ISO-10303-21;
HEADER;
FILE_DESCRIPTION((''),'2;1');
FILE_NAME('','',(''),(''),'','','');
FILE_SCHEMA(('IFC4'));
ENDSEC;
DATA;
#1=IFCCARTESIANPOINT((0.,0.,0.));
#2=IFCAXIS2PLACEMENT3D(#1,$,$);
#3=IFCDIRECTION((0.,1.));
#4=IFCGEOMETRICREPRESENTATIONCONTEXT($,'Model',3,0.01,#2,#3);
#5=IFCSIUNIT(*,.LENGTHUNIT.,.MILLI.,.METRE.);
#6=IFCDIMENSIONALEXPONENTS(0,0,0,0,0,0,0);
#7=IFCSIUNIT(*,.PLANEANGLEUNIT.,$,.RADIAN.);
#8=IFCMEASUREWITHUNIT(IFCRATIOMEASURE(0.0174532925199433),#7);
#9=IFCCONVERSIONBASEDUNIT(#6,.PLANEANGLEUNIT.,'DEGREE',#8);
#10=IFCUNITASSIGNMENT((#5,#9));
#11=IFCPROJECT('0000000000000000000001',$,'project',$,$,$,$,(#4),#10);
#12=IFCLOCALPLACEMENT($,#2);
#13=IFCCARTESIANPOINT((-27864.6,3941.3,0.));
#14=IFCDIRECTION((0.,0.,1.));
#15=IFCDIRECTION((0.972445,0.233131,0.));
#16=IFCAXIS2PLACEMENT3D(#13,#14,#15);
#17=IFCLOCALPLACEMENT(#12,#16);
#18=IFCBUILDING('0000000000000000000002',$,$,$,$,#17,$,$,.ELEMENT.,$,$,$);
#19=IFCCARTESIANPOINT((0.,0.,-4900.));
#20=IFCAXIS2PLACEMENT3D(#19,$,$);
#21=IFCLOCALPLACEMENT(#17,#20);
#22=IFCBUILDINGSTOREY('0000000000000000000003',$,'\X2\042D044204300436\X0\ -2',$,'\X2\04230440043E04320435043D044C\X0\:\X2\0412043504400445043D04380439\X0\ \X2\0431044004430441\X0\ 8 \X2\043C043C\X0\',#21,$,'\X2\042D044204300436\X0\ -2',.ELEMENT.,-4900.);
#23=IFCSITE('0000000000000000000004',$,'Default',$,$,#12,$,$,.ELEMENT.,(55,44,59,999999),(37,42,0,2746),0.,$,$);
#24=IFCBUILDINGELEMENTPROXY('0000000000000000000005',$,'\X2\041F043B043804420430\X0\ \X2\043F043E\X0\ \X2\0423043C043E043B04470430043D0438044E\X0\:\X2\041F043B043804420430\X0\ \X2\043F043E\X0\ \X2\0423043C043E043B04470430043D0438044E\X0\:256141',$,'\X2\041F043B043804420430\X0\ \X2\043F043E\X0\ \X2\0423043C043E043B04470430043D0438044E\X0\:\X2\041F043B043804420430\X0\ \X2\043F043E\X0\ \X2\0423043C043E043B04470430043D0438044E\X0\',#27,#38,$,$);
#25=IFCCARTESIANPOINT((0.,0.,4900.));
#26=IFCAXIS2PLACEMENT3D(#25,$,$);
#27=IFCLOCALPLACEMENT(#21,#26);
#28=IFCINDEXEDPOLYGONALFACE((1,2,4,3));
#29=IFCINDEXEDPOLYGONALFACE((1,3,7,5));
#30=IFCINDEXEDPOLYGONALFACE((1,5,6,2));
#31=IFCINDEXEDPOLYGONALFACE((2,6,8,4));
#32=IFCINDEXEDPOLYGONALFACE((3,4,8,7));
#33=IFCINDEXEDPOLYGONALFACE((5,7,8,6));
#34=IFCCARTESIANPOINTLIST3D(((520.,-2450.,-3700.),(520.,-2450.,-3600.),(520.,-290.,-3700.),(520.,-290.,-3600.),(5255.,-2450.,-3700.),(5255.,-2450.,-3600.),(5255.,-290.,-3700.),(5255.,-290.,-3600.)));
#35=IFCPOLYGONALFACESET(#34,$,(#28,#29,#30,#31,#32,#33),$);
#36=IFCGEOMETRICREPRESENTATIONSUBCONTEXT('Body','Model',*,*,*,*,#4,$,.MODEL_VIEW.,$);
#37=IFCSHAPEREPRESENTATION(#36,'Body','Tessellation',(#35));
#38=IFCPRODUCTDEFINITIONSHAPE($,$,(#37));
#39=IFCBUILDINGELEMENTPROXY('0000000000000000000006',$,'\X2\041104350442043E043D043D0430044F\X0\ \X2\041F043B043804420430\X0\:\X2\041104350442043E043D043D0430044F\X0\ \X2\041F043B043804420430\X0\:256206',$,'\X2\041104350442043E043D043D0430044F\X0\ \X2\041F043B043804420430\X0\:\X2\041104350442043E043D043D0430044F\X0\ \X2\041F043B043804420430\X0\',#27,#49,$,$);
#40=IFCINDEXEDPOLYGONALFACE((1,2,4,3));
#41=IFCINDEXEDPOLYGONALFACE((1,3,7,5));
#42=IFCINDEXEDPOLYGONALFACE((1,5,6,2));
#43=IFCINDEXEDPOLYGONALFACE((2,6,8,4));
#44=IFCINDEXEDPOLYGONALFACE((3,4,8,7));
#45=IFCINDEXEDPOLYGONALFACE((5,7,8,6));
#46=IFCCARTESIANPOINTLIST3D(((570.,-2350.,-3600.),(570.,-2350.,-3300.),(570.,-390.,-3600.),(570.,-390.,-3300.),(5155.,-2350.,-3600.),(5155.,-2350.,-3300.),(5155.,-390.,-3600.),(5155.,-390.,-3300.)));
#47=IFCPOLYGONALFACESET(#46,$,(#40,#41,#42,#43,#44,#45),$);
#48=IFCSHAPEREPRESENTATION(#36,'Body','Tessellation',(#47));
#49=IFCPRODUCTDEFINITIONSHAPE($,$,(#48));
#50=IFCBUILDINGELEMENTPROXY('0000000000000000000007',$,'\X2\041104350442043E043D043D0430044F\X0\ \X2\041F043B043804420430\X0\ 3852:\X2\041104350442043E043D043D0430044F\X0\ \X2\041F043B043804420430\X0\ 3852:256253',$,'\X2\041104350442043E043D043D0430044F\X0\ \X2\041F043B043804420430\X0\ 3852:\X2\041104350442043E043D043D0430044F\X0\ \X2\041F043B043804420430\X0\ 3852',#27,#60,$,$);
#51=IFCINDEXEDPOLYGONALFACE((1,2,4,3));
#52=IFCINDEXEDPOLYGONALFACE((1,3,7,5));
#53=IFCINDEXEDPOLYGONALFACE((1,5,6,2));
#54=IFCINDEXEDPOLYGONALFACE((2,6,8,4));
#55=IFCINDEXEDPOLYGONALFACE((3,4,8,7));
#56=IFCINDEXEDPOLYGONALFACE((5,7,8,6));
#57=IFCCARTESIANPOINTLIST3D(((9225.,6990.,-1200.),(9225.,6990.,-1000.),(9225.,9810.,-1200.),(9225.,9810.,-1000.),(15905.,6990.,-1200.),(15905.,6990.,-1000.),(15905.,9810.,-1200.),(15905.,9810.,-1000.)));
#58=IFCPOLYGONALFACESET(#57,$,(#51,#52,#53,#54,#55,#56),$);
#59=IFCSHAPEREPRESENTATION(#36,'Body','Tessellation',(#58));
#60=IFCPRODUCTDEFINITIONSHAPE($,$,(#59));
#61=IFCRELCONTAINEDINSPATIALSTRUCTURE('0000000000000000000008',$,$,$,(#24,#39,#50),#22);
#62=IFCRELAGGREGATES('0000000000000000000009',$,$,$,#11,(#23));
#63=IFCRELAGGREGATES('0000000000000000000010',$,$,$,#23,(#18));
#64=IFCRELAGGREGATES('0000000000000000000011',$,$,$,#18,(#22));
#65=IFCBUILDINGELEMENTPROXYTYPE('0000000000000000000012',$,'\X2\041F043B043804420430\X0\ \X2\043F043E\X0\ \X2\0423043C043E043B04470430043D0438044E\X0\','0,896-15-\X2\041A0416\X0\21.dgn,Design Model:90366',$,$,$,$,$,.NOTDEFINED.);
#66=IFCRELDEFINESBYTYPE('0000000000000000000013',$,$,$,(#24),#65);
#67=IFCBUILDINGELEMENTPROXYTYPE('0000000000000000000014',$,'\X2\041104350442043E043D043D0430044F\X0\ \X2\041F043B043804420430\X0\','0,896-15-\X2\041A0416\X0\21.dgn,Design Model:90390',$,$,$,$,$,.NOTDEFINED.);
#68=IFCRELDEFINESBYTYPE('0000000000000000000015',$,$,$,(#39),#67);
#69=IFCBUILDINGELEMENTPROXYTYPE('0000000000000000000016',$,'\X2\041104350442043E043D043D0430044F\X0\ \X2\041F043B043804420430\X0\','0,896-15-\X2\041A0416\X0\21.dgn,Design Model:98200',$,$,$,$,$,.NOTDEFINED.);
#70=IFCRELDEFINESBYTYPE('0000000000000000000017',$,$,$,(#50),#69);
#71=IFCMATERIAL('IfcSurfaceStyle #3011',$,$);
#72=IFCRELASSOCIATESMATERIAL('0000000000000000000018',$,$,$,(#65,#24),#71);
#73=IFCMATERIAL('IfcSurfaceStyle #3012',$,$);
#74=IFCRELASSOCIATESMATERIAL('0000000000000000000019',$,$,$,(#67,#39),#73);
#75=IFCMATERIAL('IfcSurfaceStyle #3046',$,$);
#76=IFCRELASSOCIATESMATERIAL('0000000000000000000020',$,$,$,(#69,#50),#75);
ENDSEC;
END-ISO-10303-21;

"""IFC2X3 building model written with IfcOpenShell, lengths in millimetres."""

from ifc_helpers import new_model, entity, si_unit, converted_unit, direction, frame, origin, origin_2d_with_axis, place, context, subcontext, project, spatial, rectangle, extrude, source, transform, mapped, material, type_object, type_shapes, element, save


model = new_model("IFC2X3")

# Units and contexts
model_context = context("Model", 3, precision=0.01, world=origin(), true_north=direction((0.0, 1.0)))
body_context = subcontext(model_context, "Body", "Model", "MODEL_VIEW")
ifc_project = project(units=[si_unit("LENGTHUNIT", "METRE", prefix="MILLI"), converted_unit("PLANEANGLEUNIT", "DEGREE", entity("IfcRatioMeasure", 0.0174532925199433), si_unit("PLANEANGLEUNIT", "RADIAN"), dimensions=[0, 0, 0, 0, 0, 0, 0])], contexts=[model_context])

# Site, building, storey
site_placement = place(None, origin())
site = spatial("IfcSite", under=ifc_project, at=site_placement, Name="Default", CompositionType="ELEMENT", RefLatitude=(55, 44, 59, 999999), RefLongitude=(37, 42, 0, 2746), RefElevation=0.0)
building_placement = place(site_placement, frame((-27864.6, 3941.3, 0.0), z_axis=(0.0, 0.0, 1.0), x_axis=(0.972445, 0.233131, 0.0)))
building = spatial("IfcBuilding", under=site, at=building_placement, CompositionType="ELEMENT")
storey_placement = place(building_placement, frame((0.0, 0.0, -4900.0)))
storey = spatial("IfcBuildingStorey", under=building, at=storey_placement, Name="Этаж -2", ObjectType="Уровень:Верхний брус 8 мм", LongName="Этаж -2", CompositionType="ELEMENT", Elevation=-4900.0)

# Building element proxies
ifc_material_1 = material(Name="IfcSurfaceStyle #3011")
building_element_proxy_type_1 = type_object("IfcBuildingElementProxyType", Name="Плита по Умолчанию", Description="0,896-15-КЖ21.dgn,Design Model:90366", PredefinedType="NOTDEFINED", material=ifc_material_1)
shared_shape_1 = source(origin(), body_context, "Body", "SweptSolid", [
    extrude(rectangle(XDim=2160.0, YDim=4735.0, at=origin_2d_with_axis()), frame((2887.5, -1370.0, -3700.0), z_axis=(0.0, 0.0, 1.0), x_axis=(0.0, 1.0, 0.0)), (0.0, 0.0, 1.0), 100.0),
])
type_shapes(building_element_proxy_type_1, [shared_shape_1])
placement = place(storey_placement, frame((0.0, 0.0, 4900.0)))
element("IfcBuildingElementProxy", 1, at=placement, inside=storey, type_object=building_element_proxy_type_1, material=ifc_material_1, Name="Плита по Умолчанию:Плита по Умолчанию:256141", ObjectType="Плита по Умолчанию:Плита по Умолчанию", context=body_context, shape_type="MappedRepresentation", body=[
    mapped(shared_shape_1, transform((0.0, 0.0, 0.0), scale=1.0)),
])
ifc_material_2 = material(Name="IfcSurfaceStyle #3012")
building_element_proxy_type_2 = type_object("IfcBuildingElementProxyType", Name="Бетонная Плита", Description="0,896-15-КЖ21.dgn,Design Model:90390", PredefinedType="NOTDEFINED", material=ifc_material_2)
shared_shape_2 = source(origin(), body_context, "Body", "SweptSolid", [
    extrude(rectangle(XDim=4585.0, YDim=1960.0, at=origin_2d_with_axis()), frame((2862.5, -1370.0, -3600.0), z_axis=(0.0, 0.0, 1.0), x_axis=(-1.0, 0.0, 0.0)), (0.0, 0.0, 1.0), 300.0),
])
type_shapes(building_element_proxy_type_2, [shared_shape_2])
element("IfcBuildingElementProxy", 2, at=placement, inside=storey, type_object=building_element_proxy_type_2, material=ifc_material_2, Name="Бетонная Плита:Бетонная Плита:256206", ObjectType="Бетонная Плита:Бетонная Плита", context=body_context, shape_type="MappedRepresentation", body=[
    mapped(shared_shape_2, transform((0.0, 0.0, 0.0), scale=1.0)),
])
ifc_material_3 = material(Name="IfcSurfaceStyle #3046")
building_element_proxy_type_3 = type_object("IfcBuildingElementProxyType", Name="Бетонная Плита", Description="0,896-15-КЖ21.dgn,Design Model:98200", PredefinedType="NOTDEFINED", material=ifc_material_3)
shared_shape_3 = source(origin(), body_context, "Body", "SweptSolid", [
    extrude(rectangle(XDim=2820.0, YDim=6680.0, at=origin_2d_with_axis()), frame((12565.0, 8400.0, -1200.0), z_axis=(0.0, 0.0, 1.0), x_axis=(0.0, 1.0, 0.0)), (0.0, 0.0, 1.0), 200.0),
])
type_shapes(building_element_proxy_type_3, [shared_shape_3])
element("IfcBuildingElementProxy", 3, at=placement, inside=storey, type_object=building_element_proxy_type_3, material=ifc_material_3, Name="Бетонная Плита 3852:Бетонная Плита 3852:256253", ObjectType="Бетонная Плита 3852:Бетонная Плита 3852", context=body_context, shape_type="MappedRepresentation", body=[
    mapped(shared_shape_3, transform((0.0, 0.0, 0.0), scale=1.0)),
])

save(model, "model.ifc")
